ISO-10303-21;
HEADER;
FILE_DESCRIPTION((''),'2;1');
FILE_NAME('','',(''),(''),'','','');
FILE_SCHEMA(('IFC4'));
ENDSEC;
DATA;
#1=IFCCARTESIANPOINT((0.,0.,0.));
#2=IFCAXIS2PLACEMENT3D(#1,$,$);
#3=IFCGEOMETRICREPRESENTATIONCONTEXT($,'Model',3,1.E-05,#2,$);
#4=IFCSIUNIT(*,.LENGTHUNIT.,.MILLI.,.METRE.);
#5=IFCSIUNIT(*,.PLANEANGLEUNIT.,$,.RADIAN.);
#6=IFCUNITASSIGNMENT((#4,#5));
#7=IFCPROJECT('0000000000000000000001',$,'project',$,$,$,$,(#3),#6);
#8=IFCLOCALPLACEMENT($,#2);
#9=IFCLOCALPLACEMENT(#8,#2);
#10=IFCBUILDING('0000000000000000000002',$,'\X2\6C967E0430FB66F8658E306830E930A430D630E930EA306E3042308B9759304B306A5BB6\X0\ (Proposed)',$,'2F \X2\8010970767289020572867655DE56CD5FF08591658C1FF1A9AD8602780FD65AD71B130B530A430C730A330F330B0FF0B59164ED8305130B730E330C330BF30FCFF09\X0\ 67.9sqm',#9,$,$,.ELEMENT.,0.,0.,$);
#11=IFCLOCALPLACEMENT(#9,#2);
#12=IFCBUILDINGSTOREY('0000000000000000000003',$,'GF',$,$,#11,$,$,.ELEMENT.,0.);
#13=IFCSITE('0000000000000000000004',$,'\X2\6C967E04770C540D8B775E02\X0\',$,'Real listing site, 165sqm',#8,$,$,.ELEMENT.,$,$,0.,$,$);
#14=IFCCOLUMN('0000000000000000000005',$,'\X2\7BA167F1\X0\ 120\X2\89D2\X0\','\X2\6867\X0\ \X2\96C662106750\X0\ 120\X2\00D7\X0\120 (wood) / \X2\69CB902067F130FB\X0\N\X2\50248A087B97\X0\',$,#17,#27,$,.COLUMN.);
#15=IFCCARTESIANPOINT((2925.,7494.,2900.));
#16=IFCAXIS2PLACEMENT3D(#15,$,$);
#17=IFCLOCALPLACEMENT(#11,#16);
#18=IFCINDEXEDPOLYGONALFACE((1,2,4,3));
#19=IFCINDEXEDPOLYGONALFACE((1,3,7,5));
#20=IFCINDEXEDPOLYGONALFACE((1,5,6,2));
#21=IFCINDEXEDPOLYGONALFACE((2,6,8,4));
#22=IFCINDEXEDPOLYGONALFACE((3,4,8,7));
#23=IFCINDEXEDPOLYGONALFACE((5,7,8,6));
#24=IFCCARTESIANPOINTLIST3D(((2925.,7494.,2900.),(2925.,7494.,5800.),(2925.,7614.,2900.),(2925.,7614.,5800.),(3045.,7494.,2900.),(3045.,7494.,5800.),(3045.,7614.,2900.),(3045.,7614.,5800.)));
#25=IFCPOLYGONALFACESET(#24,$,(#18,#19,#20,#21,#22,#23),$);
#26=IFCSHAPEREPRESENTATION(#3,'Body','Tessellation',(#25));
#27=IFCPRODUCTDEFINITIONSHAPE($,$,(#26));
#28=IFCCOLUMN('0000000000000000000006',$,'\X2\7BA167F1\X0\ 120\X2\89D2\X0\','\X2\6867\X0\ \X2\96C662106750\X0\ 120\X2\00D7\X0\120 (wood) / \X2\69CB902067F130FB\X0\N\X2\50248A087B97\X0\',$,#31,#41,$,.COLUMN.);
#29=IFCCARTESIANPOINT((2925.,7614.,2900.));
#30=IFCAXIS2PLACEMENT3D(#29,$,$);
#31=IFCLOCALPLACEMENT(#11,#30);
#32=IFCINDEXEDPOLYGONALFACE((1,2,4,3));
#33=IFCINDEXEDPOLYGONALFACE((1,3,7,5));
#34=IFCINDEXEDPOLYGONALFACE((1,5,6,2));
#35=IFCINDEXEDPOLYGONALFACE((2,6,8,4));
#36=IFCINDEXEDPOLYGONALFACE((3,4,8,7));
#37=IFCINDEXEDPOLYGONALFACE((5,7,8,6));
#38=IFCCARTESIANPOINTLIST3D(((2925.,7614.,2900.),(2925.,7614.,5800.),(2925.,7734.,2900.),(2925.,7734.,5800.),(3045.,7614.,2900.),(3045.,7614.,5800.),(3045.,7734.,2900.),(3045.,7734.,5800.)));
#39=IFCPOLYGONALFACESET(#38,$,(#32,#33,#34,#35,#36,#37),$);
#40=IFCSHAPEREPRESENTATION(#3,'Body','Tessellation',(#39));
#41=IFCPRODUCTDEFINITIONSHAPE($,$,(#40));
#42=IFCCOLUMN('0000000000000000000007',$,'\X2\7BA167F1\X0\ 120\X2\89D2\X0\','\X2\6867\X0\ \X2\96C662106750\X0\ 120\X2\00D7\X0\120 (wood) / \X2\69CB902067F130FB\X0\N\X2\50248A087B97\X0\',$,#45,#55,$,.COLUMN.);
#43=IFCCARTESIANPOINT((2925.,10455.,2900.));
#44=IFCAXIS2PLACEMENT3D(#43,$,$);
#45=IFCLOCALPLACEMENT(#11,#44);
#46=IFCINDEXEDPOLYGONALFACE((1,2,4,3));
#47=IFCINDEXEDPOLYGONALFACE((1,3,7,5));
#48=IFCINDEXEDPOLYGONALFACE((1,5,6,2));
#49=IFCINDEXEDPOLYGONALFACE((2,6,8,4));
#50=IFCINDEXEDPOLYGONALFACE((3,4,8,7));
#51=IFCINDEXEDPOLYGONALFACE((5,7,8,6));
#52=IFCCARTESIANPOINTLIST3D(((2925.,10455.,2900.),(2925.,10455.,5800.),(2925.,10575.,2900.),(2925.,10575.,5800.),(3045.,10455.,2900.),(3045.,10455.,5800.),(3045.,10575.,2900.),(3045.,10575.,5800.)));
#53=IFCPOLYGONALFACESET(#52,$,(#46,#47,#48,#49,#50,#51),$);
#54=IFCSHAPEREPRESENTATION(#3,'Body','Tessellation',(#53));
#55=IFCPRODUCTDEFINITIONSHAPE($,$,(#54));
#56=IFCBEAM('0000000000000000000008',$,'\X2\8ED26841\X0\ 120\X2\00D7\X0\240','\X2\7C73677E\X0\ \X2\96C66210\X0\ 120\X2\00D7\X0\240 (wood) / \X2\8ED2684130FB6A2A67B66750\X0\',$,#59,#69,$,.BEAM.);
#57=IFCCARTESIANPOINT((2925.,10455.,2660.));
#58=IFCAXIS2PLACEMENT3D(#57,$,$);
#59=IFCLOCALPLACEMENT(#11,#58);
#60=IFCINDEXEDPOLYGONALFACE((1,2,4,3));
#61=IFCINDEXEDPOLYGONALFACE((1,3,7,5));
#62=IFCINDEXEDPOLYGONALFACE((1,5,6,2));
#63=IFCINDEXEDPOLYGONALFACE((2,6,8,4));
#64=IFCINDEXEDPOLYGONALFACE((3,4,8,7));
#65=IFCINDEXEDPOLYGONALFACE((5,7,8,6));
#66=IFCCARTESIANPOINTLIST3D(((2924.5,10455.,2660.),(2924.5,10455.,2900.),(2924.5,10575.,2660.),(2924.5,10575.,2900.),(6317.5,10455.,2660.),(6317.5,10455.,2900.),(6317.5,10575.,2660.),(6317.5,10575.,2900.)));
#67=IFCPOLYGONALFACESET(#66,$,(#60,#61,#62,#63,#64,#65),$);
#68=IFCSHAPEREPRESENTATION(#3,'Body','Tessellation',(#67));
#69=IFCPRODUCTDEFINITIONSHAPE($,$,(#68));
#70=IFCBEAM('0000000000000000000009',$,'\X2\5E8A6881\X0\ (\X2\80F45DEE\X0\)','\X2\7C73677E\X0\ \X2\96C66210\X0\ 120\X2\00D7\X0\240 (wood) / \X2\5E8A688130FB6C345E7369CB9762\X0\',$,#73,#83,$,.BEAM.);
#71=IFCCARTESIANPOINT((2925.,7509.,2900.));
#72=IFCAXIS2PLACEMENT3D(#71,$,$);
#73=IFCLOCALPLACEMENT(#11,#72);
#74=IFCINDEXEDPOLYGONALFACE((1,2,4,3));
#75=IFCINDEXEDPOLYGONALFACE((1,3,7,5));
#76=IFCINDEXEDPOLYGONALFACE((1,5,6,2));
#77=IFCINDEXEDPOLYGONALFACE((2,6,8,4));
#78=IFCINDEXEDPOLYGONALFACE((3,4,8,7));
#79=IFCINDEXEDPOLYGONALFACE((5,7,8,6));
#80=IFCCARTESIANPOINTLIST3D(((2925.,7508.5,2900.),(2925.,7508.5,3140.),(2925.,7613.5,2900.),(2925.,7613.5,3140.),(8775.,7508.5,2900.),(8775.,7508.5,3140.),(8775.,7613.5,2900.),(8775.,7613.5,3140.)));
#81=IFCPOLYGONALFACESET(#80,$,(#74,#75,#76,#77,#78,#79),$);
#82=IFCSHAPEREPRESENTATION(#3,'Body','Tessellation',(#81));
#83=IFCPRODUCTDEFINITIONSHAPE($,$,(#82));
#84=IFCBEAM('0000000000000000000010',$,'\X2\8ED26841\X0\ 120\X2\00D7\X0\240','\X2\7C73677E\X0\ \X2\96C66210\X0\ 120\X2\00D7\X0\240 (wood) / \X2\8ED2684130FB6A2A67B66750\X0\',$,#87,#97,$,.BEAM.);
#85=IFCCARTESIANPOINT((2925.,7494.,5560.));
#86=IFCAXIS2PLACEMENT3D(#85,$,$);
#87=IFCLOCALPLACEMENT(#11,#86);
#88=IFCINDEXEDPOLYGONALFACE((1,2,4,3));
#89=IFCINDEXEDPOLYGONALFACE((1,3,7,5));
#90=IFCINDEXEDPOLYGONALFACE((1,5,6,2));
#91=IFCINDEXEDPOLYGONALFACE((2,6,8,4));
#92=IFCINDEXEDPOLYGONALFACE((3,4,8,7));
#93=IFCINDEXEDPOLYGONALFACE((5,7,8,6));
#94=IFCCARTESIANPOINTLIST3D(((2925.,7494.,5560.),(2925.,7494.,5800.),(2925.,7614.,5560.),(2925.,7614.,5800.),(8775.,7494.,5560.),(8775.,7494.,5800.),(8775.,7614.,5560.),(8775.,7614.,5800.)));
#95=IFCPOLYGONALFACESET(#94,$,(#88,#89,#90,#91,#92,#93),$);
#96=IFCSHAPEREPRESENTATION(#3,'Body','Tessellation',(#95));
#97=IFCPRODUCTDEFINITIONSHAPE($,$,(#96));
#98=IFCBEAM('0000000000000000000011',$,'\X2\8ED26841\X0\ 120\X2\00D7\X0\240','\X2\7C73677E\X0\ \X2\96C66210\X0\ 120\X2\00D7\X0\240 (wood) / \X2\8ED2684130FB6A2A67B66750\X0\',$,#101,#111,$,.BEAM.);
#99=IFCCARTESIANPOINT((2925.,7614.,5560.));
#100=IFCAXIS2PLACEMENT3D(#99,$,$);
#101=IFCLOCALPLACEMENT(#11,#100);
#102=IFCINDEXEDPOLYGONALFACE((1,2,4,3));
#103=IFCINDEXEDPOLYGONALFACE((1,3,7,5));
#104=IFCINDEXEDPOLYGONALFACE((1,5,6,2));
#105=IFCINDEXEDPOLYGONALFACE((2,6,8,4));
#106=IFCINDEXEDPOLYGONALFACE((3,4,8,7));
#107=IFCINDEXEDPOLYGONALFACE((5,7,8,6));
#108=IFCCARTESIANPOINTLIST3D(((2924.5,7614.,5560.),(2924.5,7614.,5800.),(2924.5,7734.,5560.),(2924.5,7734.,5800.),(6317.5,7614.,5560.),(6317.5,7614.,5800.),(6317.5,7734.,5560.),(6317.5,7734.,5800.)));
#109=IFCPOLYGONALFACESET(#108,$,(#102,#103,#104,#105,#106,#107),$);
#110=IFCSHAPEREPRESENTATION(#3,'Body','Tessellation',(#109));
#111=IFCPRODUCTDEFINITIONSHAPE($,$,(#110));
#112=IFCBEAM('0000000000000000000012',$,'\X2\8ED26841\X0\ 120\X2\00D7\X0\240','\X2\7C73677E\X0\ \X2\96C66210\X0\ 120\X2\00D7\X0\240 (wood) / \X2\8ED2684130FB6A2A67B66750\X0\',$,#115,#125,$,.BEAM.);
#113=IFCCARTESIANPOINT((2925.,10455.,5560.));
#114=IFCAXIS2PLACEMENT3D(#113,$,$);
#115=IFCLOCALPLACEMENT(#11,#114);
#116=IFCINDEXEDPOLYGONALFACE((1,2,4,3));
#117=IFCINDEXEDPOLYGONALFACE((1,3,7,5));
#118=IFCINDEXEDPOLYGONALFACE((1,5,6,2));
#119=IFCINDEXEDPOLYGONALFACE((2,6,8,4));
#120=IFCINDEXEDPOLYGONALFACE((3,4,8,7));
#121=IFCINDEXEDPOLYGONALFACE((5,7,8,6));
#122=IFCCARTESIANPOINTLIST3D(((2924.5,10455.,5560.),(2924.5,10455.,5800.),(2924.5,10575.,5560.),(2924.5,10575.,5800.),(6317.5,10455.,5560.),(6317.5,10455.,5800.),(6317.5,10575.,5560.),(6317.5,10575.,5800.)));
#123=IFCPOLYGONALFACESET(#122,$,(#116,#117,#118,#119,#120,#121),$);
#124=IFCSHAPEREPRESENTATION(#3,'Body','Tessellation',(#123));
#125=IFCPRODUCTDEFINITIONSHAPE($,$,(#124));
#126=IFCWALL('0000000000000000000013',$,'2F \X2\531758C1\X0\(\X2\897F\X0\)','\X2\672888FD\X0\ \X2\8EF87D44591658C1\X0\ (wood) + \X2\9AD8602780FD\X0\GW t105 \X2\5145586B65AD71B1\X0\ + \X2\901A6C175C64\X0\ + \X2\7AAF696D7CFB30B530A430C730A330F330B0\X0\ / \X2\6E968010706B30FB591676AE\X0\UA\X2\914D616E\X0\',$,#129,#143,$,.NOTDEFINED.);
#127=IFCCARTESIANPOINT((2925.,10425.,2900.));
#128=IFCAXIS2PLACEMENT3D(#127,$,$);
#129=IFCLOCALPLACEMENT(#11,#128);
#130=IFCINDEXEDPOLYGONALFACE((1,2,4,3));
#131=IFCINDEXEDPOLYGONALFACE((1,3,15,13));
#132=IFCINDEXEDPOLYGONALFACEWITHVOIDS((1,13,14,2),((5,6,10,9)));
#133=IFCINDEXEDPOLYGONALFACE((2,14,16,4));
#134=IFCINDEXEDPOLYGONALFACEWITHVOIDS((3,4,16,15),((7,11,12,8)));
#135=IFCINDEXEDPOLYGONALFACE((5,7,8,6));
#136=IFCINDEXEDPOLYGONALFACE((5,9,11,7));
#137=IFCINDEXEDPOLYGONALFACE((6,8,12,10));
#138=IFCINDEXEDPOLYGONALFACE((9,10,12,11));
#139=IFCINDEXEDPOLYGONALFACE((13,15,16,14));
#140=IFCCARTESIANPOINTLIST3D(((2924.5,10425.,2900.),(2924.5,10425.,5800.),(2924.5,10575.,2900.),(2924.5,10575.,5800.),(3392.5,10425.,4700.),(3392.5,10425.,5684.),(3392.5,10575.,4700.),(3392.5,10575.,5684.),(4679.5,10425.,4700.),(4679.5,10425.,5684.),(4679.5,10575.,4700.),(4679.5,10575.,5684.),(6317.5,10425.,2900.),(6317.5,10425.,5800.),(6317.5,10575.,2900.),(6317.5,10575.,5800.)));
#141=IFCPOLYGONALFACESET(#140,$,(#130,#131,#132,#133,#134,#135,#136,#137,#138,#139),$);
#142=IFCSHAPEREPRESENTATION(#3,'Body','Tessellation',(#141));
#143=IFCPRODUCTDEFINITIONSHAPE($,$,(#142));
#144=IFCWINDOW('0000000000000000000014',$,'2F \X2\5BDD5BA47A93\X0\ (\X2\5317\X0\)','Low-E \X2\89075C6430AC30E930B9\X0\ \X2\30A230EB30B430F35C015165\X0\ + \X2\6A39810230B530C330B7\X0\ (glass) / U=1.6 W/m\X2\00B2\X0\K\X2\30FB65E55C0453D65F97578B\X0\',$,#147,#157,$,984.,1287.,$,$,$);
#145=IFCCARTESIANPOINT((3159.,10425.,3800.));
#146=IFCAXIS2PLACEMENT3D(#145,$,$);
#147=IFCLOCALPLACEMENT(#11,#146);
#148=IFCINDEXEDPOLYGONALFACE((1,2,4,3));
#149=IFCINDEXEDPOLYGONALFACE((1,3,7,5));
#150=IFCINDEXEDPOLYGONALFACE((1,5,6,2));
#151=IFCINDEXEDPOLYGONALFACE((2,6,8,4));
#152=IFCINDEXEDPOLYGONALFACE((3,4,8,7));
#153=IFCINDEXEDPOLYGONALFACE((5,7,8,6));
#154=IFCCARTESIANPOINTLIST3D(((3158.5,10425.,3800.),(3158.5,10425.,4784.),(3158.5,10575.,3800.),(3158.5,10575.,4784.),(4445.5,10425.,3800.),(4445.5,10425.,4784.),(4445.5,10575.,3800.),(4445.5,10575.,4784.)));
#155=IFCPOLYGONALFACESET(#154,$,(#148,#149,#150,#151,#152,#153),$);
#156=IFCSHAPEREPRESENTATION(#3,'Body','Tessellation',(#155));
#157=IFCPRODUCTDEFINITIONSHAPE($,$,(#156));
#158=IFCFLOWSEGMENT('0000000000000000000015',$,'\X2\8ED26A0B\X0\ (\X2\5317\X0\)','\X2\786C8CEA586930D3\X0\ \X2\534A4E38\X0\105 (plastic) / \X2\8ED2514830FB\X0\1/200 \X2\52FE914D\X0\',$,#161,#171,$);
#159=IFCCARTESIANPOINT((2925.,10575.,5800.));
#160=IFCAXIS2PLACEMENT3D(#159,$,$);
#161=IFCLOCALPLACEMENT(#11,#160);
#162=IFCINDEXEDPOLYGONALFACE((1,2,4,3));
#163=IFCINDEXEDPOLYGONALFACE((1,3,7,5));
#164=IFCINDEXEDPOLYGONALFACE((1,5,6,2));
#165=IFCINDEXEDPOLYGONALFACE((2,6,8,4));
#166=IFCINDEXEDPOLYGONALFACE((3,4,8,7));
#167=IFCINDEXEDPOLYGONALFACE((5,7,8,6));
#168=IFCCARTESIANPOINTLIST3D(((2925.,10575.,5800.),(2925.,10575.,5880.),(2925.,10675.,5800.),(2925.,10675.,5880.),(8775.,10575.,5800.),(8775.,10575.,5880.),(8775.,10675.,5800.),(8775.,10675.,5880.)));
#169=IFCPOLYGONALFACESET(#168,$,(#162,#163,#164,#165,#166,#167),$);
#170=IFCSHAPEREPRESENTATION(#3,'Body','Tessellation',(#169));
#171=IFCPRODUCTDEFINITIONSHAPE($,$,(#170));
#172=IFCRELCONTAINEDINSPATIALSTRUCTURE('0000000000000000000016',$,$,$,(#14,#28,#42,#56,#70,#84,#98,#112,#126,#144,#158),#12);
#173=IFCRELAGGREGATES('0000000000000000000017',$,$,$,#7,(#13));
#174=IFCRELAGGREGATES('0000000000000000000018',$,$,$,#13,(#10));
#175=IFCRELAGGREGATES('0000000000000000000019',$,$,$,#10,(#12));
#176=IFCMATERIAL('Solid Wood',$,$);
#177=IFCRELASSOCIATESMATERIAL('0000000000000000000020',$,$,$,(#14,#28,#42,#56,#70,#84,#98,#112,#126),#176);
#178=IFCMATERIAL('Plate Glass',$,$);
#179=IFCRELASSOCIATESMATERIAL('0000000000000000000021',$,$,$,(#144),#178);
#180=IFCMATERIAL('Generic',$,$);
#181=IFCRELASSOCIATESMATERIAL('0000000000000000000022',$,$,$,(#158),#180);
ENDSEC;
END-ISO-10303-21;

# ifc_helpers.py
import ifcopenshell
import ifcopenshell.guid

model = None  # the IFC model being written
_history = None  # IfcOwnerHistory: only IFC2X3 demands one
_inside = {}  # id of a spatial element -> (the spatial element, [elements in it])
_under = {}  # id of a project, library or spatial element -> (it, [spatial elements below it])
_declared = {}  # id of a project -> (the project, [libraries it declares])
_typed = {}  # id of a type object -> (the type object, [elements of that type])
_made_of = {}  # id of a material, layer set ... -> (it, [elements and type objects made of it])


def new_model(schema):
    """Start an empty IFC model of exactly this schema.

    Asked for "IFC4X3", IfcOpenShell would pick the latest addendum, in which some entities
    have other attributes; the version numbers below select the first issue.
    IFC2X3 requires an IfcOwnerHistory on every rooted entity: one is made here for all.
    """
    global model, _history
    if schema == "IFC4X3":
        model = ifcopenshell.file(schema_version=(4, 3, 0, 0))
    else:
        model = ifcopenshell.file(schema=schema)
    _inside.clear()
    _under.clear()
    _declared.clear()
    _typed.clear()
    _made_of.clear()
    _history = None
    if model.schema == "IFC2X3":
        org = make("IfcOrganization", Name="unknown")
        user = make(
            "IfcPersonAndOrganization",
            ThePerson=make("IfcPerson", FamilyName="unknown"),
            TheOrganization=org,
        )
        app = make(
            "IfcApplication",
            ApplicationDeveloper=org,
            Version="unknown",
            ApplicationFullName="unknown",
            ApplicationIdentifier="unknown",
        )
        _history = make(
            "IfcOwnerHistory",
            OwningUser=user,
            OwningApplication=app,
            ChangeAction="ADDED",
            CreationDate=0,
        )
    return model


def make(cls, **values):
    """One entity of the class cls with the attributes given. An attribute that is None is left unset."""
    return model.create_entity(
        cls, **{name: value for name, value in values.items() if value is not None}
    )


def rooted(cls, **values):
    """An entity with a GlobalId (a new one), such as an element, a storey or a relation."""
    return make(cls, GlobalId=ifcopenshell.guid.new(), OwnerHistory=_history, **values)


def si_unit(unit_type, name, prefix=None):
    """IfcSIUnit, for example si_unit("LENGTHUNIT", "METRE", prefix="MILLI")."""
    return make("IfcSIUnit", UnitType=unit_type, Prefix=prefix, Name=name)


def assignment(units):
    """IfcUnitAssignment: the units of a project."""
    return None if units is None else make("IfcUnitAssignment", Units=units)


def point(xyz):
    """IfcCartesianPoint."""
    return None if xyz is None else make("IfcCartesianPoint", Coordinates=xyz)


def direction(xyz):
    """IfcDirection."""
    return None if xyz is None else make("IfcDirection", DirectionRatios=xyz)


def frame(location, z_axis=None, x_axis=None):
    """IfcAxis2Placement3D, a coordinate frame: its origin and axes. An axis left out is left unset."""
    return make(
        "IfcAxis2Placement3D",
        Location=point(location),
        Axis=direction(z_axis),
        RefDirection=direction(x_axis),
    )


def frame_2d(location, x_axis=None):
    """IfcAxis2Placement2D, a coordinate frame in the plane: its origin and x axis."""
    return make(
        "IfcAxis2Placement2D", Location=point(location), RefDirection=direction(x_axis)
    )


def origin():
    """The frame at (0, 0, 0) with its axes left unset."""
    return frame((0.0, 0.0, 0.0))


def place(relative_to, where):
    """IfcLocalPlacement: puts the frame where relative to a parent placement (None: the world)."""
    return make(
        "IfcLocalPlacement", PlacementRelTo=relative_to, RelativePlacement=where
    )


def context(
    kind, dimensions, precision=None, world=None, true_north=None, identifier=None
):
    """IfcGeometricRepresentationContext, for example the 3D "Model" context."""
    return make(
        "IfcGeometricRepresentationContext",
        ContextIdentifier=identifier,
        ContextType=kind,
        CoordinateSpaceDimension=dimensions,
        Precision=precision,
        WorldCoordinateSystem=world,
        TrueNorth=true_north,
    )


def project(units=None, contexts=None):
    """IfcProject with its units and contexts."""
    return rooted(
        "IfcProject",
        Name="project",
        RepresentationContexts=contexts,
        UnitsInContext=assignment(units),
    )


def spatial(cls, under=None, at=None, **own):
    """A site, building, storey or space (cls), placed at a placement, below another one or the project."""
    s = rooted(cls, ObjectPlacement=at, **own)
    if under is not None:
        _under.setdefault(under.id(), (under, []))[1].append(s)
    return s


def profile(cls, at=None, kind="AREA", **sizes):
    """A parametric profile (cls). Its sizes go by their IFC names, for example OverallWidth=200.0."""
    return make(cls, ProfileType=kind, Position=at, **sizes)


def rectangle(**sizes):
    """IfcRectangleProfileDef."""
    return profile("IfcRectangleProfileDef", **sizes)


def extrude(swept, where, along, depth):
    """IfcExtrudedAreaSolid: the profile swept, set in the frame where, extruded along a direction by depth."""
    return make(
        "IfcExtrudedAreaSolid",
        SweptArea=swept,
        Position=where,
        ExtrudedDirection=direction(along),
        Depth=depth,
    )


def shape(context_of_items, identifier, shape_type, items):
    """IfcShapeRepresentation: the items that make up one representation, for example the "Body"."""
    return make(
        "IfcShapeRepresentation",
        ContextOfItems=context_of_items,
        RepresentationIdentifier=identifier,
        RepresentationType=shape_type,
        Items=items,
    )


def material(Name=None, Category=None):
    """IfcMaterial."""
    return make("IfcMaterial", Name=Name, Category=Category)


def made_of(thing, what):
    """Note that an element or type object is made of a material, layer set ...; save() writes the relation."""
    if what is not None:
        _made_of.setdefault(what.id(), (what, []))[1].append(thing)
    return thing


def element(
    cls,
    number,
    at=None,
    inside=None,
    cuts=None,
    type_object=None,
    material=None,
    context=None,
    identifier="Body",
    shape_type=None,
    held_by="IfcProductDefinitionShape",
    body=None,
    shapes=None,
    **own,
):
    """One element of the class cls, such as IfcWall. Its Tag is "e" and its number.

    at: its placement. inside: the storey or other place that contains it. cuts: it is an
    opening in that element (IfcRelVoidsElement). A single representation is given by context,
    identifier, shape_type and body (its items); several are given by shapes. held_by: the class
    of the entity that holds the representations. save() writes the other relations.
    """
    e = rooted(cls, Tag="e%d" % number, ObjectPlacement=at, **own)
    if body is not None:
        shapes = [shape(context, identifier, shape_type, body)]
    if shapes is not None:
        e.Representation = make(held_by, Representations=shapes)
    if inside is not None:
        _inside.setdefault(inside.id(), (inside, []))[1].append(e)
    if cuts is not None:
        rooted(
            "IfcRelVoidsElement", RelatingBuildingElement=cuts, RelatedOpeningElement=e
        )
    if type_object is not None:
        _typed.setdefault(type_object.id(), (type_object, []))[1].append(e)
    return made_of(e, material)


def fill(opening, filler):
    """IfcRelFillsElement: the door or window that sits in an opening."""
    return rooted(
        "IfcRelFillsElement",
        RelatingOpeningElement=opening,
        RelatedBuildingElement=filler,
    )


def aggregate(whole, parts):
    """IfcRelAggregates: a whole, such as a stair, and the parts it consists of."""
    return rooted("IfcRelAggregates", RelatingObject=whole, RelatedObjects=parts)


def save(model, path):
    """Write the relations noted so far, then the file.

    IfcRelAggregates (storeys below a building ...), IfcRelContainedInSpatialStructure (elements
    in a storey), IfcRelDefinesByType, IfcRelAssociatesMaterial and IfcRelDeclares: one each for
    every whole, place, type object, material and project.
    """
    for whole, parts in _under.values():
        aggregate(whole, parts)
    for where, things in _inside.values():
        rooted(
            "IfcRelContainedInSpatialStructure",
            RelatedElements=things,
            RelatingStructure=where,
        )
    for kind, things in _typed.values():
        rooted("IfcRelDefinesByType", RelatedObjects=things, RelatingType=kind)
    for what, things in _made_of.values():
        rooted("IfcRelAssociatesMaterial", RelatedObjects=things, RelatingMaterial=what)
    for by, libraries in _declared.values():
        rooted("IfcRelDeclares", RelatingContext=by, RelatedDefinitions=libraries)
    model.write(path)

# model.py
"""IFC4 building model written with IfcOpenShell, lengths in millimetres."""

from ifc_helpers import new_model, si_unit, frame, frame_2d, origin, place, context, project, spatial, rectangle, extrude, material, element, fill, save


model = new_model("IFC4")

# Units and contexts
model_context = context("Model", 3, precision=1e-05, world=origin())
ifc_project = project(units=[si_unit("LENGTHUNIT", "METRE", prefix="MILLI"), si_unit("PLANEANGLEUNIT", "RADIAN")], contexts=[model_context])

# Site, building, storey
site_placement = place(None, origin())
site = spatial("IfcSite", under=ifc_project, at=site_placement, Name="沖縄県名護市", ObjectType="Real listing site, 165sqm", CompositionType="ELEMENT", RefElevation=0.0)
building_placement = place(site_placement, origin())
building = spatial("IfcBuilding", under=site, at=building_placement, Name="沖縄・書斎とライブラリのある静かな家 (Proposed)", ObjectType="2F 耐震木造在来工法（外壁：高性能断熱サイディング＋外付けシャッター） 67.9sqm", CompositionType="ELEMENT", ElevationOfRefHeight=0.0, ElevationOfTerrain=0.0)
storey_placement = place(building_placement, origin())
storey = spatial("IfcBuildingStorey", under=building, at=storey_placement, Name="GF", CompositionType="ELEMENT", Elevation=0.0)

# Columns
ifc_material_1 = material(Name="Solid Wood")
column_1_placement = place(storey_placement, frame((2925.0, 7494.0, 2900.0)))
element("IfcColumn", 1, at=column_1_placement, inside=storey, material=ifc_material_1, Name="管柱 120角", Description="桧 集成材 120×120 (wood) / 構造柱・N値計算", PredefinedType="COLUMN", context=model_context, shape_type="SweptSolid", body=[
    extrude(rectangle(XDim=120.0, YDim=120.0, at=frame_2d((60.0, 60.0))), frame((2925.0, 7494.0, 2900.0)), (0.0, 0.0, 1.0), 2900.0),
])
column_2_placement = place(storey_placement, frame((2925.0, 7614.0, 2900.0)))
element("IfcColumn", 2, at=column_2_placement, inside=storey, material=ifc_material_1, Name="管柱 120角", Description="桧 集成材 120×120 (wood) / 構造柱・N値計算", PredefinedType="COLUMN", context=model_context, shape_type="SweptSolid", body=[
    extrude(rectangle(XDim=120.0, YDim=120.0, at=frame_2d((60.0, 60.0))), frame((2925.0, 7614.0, 2900.0)), (0.0, 0.0, 1.0), 2900.0),
])
column_3_placement = place(storey_placement, frame((2925.0, 10455.0, 2900.0)))
element("IfcColumn", 3, at=column_3_placement, inside=storey, material=ifc_material_1, Name="管柱 120角", Description="桧 集成材 120×120 (wood) / 構造柱・N値計算", PredefinedType="COLUMN", context=model_context, shape_type="SweptSolid", body=[
    extrude(rectangle(XDim=120.0, YDim=120.0, at=frame_2d((60.0, 60.0))), frame((2925.0, 10455.0, 2900.0)), (0.0, 0.0, 1.0), 2900.0),
])

# Beams
beam_1_placement = place(storey_placement, frame((2925.0, 10455.0, 2660.0)))
element("IfcBeam", 4, at=beam_1_placement, inside=storey, material=ifc_material_1, Name="軒桁 120×240", Description="米松 集成 120×240 (wood) / 軒桁・横架材", PredefinedType="BEAM", context=model_context, shape_type="SweptSolid", body=[
    extrude(rectangle(XDim=3393.0, YDim=120.0, at=frame_2d((1696.0, 60.0))), frame((2925.0, 10455.0, 2660.0)), (0.0, 0.0, 1.0), 240.0),
])
beam_2_placement = place(storey_placement, frame((2925.0, 7509.0, 2900.0)))
element("IfcBeam", 5, at=beam_2_placement, inside=storey, material=ifc_material_1, Name="床梁 (胴差)", Description="米松 集成 120×240 (wood) / 床梁・水平構面", PredefinedType="BEAM", context=model_context, shape_type="SweptSolid", body=[
    extrude(rectangle(XDim=5850.0, YDim=105.0, at=frame_2d((2925.0, 52.0))), frame((2925.0, 7509.0, 2900.0)), (0.0, 0.0, 1.0), 240.0),
])
beam_3_placement = place(storey_placement, frame((2925.0, 7494.0, 5560.0)))
element("IfcBeam", 6, at=beam_3_placement, inside=storey, material=ifc_material_1, Name="軒桁 120×240", Description="米松 集成 120×240 (wood) / 軒桁・横架材", PredefinedType="BEAM", context=model_context, shape_type="SweptSolid", body=[
    extrude(rectangle(XDim=5850.0, YDim=120.0, at=frame_2d((2925.0, 60.0))), frame((2925.0, 7494.0, 5560.0)), (0.0, 0.0, 1.0), 240.0),
])
beam_4_placement = place(storey_placement, frame((2925.0, 7614.0, 5560.0)))
element("IfcBeam", 7, at=beam_4_placement, inside=storey, material=ifc_material_1, Name="軒桁 120×240", Description="米松 集成 120×240 (wood) / 軒桁・横架材", PredefinedType="BEAM", context=model_context, shape_type="SweptSolid", body=[
    extrude(rectangle(XDim=3393.0, YDim=120.0, at=frame_2d((1696.0, 60.0))), frame((2925.0, 7614.0, 5560.0)), (0.0, 0.0, 1.0), 240.0),
])
beam_5_placement = place(storey_placement, frame((2925.0, 10455.0, 5560.0)))
element("IfcBeam", 8, at=beam_5_placement, inside=storey, material=ifc_material_1, Name="軒桁 120×240", Description="米松 集成 120×240 (wood) / 軒桁・横架材", PredefinedType="BEAM", context=model_context, shape_type="SweptSolid", body=[
    extrude(rectangle(XDim=3393.0, YDim=120.0, at=frame_2d((1696.0, 60.0))), frame((2925.0, 10455.0, 5560.0)), (0.0, 0.0, 1.0), 240.0),
])

# Wall, opening, window
wall_1_placement = place(storey_placement, frame((2925.0, 10425.0, 2900.0)))
wall_1 = element("IfcWall", 9, at=wall_1_placement, inside=storey, material=ifc_material_1, Name="2F 北壁(西)", Description="木製 軸組外壁 (wood) + 高性能GW t105 充填断熱 + 通気層 + 窯業系サイディング / 準耐火・外皮UA配慮", PredefinedType="NOTDEFINED", context=model_context, shape_type="SweptSolid", body=[
    extrude(rectangle(XDim=3393.0, YDim=150.0, at=frame_2d((1696.0, 75.0))), frame((2925.0, 10425.0, 2900.0)), (0.0, 0.0, 1.0), 2900.0),
])
opening_placement = place(storey_placement, frame((3159.0, 10425.0, 3800.0)))
opening = element("IfcOpeningElement", 10, at=opening_placement, cuts=wall_1, PredefinedType="NOTDEFINED", context=model_context, shape_type="SweptSolid", body=[
    extrude(rectangle(XDim=1287.0, YDim=150.0, at=frame_2d((643.0, 75.0))), frame((3159.0, 10425.0, 3800.0)), (0.0, 0.0, 1.0), 984.0),
])
ifc_material_2 = material(Name="Plate Glass")
window_placement = place(storey_placement, frame((3159.0, 10425.0, 3800.0)))
window = element("IfcWindow", 11, at=window_placement, inside=storey, material=ifc_material_2, Name="2F 寝室窓 (北)", Description="Low-E 複層ガラス アルゴン封入 + 樹脂サッシ (glass) / U=1.6 W/m²K・日射取得型", OverallHeight=984.0, OverallWidth=1287.0, context=model_context, shape_type="SweptSolid", body=[
    extrude(rectangle(XDim=1287.0, YDim=150.0, at=frame_2d((643.0, 75.0))), frame((3159.0, 10425.0, 3800.0)), (0.0, 0.0, 1.0), 984.0),
])
fill(opening, window)

# Shared definitions
ifc_material_3 = material(Name="Generic")

# Flow segment
flow_segment_placement = place(storey_placement, frame((2925.0, 10575.0, 5800.0)))
element("IfcFlowSegment", 12, at=flow_segment_placement, inside=storey, material=ifc_material_3, Name="軒樋 (北)", Description="硬質塩ビ 半丸105 (plastic) / 軒先・1/200 勾配", context=model_context, shape_type="SweptSolid", body=[
    extrude(rectangle(XDim=5850.0, YDim=100.0, at=frame_2d((2925.0, 50.0))), frame((2925.0, 10575.0, 5800.0)), (0.0, 0.0, 1.0), 80.0),
])

save(model, "model.ifc")
